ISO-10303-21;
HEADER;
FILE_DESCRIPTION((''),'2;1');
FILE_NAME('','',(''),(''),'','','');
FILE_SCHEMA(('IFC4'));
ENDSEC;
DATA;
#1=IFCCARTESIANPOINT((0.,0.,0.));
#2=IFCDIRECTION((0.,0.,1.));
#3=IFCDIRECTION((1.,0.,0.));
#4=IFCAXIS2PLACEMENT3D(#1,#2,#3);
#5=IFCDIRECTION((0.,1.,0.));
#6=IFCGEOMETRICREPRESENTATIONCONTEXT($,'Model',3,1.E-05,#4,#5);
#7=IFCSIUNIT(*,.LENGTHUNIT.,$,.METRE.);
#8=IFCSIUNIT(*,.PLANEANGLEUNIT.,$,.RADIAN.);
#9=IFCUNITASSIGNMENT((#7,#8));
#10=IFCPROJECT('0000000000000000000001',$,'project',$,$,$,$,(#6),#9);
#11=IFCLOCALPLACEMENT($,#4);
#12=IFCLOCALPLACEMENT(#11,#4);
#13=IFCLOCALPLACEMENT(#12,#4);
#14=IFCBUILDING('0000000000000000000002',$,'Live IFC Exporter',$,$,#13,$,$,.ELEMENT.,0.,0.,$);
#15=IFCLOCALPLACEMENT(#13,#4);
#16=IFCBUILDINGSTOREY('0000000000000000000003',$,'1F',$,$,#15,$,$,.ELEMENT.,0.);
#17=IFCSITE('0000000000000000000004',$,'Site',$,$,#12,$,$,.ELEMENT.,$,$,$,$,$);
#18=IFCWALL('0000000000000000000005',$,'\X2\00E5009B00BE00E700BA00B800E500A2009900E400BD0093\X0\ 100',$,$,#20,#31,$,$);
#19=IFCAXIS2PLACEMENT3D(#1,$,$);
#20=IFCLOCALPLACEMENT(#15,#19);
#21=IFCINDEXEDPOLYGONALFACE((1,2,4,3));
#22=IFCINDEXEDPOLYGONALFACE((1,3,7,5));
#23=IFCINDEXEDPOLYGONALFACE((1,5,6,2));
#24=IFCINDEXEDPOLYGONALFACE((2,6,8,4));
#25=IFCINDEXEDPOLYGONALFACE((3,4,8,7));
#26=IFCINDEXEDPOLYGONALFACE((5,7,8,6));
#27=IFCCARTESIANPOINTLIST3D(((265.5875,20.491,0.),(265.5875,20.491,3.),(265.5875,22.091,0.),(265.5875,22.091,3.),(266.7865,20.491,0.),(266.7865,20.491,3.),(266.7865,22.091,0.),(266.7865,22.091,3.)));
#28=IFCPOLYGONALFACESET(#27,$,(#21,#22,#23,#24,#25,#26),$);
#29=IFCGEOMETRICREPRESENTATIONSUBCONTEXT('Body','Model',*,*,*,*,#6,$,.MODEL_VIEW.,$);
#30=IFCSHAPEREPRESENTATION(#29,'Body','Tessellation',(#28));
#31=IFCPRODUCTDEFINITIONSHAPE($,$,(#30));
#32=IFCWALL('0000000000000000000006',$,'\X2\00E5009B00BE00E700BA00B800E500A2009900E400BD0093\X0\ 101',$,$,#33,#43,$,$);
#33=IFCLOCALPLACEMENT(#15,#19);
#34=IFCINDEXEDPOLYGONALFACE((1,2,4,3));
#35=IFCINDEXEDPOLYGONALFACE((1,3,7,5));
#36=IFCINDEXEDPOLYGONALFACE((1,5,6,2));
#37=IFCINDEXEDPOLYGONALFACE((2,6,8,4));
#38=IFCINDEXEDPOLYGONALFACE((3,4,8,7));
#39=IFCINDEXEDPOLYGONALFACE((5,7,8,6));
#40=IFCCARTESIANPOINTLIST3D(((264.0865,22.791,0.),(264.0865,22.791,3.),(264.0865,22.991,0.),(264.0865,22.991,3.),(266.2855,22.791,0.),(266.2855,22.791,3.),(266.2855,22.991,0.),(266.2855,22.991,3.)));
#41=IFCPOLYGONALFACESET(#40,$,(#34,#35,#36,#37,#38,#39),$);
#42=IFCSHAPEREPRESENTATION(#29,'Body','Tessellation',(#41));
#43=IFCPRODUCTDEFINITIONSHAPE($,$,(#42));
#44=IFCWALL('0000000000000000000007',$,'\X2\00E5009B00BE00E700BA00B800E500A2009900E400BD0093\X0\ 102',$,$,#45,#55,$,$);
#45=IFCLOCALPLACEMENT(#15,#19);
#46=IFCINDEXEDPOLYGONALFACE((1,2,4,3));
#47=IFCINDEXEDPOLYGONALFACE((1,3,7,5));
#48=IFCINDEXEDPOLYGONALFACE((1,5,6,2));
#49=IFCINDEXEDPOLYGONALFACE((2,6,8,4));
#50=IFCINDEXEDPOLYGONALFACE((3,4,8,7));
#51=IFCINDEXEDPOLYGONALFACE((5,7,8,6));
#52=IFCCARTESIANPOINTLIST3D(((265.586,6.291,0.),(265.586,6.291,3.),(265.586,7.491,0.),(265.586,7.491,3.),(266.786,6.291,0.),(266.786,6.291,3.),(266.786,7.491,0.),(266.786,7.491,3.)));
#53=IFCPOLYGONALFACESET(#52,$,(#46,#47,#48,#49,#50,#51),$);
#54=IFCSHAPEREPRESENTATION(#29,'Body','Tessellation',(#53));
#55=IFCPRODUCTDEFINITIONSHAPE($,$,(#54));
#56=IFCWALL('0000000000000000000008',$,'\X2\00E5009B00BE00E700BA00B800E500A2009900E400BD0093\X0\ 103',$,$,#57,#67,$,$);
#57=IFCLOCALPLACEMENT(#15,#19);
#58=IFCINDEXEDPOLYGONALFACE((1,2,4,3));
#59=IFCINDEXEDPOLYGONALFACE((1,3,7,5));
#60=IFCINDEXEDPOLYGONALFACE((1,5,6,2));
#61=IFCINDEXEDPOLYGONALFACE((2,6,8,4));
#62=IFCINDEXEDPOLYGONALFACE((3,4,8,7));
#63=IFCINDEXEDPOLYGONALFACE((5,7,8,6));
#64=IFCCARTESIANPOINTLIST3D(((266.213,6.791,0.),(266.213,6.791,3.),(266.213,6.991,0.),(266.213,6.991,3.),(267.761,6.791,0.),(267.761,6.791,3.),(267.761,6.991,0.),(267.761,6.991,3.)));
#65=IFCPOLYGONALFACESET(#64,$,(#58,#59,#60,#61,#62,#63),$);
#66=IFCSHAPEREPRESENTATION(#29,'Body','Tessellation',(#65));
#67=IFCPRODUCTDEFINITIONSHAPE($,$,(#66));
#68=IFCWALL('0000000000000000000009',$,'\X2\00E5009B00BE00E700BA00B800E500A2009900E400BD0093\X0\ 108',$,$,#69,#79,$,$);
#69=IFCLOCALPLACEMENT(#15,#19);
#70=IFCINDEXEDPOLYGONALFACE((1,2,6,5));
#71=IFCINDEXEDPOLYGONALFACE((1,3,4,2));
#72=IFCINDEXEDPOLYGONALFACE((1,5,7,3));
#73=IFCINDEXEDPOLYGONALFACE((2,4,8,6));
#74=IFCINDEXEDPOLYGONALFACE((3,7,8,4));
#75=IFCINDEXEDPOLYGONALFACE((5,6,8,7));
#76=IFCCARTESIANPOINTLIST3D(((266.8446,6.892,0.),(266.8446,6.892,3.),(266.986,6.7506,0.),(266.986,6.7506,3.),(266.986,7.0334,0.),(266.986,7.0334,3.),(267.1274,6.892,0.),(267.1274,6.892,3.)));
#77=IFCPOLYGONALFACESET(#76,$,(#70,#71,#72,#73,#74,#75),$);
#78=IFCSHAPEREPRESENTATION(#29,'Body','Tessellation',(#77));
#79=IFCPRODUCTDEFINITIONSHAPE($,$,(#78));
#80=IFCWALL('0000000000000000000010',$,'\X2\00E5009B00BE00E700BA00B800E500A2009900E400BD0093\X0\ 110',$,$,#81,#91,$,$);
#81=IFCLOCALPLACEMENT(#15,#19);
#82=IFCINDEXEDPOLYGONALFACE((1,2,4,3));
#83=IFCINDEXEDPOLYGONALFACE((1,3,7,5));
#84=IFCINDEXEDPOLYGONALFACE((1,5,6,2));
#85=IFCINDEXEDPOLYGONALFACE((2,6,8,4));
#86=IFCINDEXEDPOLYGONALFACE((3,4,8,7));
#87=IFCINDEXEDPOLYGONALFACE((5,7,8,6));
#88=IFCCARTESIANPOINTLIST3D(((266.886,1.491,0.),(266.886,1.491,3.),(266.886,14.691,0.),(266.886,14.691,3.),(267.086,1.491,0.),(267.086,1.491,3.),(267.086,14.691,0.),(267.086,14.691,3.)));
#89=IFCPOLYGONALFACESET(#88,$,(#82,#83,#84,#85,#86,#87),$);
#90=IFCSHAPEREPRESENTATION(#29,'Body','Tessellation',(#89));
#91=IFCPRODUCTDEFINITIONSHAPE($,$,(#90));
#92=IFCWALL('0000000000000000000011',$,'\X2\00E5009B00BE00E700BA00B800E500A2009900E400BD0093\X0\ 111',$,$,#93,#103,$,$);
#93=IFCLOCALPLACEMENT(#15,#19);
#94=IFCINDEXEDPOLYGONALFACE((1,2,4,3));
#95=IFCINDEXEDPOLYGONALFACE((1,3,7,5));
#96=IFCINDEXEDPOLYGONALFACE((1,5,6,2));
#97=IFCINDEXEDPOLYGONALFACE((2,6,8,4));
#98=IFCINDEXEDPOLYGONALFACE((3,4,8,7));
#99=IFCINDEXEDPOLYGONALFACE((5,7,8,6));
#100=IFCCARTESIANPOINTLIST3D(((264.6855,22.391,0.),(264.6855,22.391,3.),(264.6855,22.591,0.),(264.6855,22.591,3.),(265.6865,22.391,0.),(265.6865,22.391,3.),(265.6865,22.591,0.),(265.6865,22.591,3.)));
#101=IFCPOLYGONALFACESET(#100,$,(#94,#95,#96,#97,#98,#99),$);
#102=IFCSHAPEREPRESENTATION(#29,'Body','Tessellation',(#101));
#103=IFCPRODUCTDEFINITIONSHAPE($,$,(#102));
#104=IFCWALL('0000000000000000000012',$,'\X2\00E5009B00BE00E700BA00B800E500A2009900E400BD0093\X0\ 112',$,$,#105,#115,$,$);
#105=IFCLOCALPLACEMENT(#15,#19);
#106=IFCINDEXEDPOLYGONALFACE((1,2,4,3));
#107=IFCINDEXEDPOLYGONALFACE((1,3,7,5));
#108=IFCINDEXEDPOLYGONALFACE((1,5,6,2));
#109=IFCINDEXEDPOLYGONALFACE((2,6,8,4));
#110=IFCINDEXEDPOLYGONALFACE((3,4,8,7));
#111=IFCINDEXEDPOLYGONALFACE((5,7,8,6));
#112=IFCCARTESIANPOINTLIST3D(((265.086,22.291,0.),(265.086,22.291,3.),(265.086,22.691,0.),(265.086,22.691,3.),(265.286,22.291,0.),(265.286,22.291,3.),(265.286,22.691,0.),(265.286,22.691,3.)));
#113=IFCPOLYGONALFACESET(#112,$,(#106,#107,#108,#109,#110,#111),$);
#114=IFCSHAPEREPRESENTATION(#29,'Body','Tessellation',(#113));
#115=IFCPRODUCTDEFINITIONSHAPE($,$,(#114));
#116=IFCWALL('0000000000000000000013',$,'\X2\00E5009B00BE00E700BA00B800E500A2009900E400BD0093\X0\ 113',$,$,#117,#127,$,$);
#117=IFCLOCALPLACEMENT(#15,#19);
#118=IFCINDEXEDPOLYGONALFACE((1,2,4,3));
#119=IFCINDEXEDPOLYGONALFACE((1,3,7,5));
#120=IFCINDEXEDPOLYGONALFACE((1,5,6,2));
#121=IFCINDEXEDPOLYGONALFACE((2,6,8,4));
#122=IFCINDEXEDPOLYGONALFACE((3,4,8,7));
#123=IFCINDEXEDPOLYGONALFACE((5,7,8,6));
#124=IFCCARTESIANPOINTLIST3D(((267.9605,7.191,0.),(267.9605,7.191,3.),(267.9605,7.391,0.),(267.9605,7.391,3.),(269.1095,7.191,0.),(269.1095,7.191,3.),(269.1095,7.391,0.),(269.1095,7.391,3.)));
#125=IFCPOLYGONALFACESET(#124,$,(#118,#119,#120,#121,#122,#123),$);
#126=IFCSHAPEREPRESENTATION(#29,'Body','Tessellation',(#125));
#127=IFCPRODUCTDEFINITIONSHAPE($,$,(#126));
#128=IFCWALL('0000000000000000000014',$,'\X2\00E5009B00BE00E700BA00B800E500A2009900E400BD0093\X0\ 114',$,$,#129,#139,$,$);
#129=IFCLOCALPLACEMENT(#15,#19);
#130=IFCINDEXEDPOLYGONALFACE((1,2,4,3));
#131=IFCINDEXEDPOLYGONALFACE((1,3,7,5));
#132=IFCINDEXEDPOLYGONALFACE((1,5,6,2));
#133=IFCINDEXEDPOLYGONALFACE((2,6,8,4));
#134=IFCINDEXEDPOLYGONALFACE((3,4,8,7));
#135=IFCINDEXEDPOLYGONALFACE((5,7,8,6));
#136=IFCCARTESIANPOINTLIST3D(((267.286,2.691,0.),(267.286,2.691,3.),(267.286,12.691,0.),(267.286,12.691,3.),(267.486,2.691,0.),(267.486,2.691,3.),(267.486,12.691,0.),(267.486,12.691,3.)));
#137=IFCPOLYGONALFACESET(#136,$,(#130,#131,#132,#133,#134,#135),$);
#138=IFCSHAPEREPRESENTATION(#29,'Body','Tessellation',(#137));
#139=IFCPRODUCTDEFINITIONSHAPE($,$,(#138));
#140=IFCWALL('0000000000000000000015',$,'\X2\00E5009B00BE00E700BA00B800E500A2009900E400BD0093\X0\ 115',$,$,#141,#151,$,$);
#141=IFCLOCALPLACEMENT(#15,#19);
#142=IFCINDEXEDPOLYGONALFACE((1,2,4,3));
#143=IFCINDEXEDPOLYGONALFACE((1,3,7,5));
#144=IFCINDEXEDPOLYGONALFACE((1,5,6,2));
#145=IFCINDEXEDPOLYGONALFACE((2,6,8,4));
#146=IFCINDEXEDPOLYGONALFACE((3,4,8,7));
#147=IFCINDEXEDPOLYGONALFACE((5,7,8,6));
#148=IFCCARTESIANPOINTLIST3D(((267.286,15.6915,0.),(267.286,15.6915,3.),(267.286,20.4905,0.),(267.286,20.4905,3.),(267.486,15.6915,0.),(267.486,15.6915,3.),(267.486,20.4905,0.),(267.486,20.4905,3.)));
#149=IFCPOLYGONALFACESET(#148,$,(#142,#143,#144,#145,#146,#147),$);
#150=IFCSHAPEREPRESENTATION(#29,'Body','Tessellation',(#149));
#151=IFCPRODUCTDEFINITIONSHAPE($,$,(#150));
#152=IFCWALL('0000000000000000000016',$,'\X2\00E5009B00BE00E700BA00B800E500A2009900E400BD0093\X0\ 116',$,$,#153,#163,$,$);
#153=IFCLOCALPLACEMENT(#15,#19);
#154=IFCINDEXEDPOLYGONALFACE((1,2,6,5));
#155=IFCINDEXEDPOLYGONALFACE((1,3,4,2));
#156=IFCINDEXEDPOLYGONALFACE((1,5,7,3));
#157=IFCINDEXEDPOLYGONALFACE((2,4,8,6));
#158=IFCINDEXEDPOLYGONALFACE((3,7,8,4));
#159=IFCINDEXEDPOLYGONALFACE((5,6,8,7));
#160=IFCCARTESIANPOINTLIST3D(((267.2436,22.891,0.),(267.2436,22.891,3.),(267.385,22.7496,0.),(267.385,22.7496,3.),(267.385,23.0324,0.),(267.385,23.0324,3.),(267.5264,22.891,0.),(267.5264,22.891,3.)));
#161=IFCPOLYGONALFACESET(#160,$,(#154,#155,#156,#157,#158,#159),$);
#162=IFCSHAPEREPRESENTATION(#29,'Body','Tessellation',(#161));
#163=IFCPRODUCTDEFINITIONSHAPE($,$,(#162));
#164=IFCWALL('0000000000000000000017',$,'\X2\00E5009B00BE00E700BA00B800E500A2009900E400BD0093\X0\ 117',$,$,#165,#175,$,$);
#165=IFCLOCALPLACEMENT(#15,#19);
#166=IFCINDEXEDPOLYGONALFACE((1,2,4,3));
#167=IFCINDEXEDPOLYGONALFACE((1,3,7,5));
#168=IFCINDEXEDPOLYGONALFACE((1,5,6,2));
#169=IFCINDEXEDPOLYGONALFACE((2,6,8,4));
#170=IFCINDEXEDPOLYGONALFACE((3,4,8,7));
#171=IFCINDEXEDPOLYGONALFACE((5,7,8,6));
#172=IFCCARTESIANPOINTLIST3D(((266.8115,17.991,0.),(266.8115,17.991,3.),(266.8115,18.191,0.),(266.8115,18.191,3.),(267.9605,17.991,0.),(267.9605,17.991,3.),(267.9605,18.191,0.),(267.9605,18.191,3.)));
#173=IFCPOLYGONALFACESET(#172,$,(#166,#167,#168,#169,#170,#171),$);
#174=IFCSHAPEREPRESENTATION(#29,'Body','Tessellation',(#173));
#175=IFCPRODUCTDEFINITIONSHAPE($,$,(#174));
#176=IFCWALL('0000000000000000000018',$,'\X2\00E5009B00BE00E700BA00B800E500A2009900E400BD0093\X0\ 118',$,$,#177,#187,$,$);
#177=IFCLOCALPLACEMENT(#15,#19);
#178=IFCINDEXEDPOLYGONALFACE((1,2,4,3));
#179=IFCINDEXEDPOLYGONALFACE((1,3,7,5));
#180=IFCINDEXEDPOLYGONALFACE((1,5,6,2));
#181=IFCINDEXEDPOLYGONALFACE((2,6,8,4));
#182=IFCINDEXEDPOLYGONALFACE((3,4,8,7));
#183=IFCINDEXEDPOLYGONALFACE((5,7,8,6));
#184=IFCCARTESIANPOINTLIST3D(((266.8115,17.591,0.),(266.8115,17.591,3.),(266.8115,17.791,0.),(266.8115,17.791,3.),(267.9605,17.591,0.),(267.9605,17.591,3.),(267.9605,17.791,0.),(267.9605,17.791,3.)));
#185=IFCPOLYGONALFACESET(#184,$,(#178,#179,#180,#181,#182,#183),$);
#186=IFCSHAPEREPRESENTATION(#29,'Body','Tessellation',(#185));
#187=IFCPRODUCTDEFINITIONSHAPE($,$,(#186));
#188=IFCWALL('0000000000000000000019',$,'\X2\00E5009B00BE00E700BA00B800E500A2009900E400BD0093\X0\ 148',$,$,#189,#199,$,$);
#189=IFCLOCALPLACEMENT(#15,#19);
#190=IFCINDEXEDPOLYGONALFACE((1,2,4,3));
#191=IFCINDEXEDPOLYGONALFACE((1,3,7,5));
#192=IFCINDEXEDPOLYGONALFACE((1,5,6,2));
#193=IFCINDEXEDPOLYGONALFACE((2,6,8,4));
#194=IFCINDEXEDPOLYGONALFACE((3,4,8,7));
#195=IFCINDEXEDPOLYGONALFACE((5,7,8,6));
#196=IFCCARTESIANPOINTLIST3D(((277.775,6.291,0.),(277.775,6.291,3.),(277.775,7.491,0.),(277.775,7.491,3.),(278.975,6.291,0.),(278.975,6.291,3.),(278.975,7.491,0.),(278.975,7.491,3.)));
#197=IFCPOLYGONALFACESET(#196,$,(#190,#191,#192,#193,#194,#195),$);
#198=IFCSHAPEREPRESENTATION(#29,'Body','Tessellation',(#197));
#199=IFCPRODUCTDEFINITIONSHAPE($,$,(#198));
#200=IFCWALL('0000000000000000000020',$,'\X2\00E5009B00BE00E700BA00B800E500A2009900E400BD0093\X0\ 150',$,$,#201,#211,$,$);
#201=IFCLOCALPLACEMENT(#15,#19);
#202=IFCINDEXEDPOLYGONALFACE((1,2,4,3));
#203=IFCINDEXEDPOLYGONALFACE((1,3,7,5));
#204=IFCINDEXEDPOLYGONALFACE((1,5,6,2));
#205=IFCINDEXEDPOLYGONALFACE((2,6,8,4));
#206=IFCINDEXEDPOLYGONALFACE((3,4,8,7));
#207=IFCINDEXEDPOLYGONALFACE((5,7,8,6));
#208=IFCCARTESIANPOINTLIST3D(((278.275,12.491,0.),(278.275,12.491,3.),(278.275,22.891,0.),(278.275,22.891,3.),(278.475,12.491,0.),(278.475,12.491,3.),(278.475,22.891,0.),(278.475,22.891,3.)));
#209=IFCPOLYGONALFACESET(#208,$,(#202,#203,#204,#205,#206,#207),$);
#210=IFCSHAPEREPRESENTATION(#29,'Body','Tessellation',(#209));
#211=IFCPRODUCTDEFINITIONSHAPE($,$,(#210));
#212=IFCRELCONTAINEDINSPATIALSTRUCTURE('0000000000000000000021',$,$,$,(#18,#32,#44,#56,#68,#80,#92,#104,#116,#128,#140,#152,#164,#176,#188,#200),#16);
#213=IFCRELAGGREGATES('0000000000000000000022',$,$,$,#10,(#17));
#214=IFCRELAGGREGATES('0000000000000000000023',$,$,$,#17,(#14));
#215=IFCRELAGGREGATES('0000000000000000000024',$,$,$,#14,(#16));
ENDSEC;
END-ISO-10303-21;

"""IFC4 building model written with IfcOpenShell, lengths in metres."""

from ifc_helpers import new_model, si_unit, direction, frame, frame_2d, origin_with_axes, place, context, subcontext, project, spatial, rectangle, extrude, element, save


model = new_model("IFC4")

# Units and contexts
model_context = context("Model", 3, precision=1e-05, world=origin_with_axes(), true_north=direction((0.0, 1.0, 0.0)))
body_context = subcontext(model_context, "Body", "Model", "MODEL_VIEW")
ifc_project = project(units=[si_unit("LENGTHUNIT", "METRE"), si_unit("PLANEANGLEUNIT", "RADIAN")], contexts=[model_context])

# Site, building, storey
placement = place(None, origin_with_axes())
site_placement = place(placement, origin_with_axes())
site = spatial("IfcSite", under=ifc_project, at=site_placement, Name="Site", CompositionType="ELEMENT")
building_placement = place(site_placement, origin_with_axes())
building = spatial("IfcBuilding", under=site, at=building_placement, Name="Live IFC Exporter", CompositionType="ELEMENT", ElevationOfRefHeight=0.0, ElevationOfTerrain=0.0)
storey_placement = place(building_placement, origin_with_axes())
storey = spatial("IfcBuildingStorey", under=building, at=storey_placement, Name="1F", CompositionType="ELEMENT", Elevation=0.0)

# Walls
wall_1_placement = place(storey_placement, frame((266.187, 21.291, 0.0), z_axis=(0.0, 0.0, 1.0), x_axis=(1.0, 0.0, 0.0)))
element("IfcWall", 1, at=wall_1_placement, inside=storey, Name="å\u009b¾çº¸å¢\u0099ä½\u0093 100", context=body_context, shape_type="SweptSolid", body=[
    extrude(rectangle(XDim=1.199, YDim=1.6, at=frame_2d((0.0, 0.0), x_axis=(1.0, 0.0, 0.0))), frame((0.0, 0.0, 0.0), z_axis=(0.0, 0.0, 1.0)), (0.0, 0.0, 1.0), 3.0),
])
wall_2_placement = place(storey_placement, frame((265.186, 22.891, 0.0), z_axis=(0.0, 0.0, 1.0), x_axis=(1.0, 0.0, 0.0)))
element("IfcWall", 2, at=wall_2_placement, inside=storey, Name="å\u009b¾çº¸å¢\u0099ä½\u0093 101", context=body_context, shape_type="SweptSolid", body=[
    extrude(rectangle(XDim=2.199, YDim=0.2, at=frame_2d((0.0, 0.0), x_axis=(1.0, 0.0, 0.0))), frame((0.0, 0.0, 0.0), z_axis=(0.0, 0.0, 1.0)), (0.0, 0.0, 1.0), 3.0),
])
wall_3_placement = place(storey_placement, frame((266.186, 6.891, 0.0), z_axis=(0.0, 0.0, 1.0), x_axis=(1.0, 0.0, 0.0)))
element("IfcWall", 3, at=wall_3_placement, inside=storey, Name="å\u009b¾çº¸å¢\u0099ä½\u0093 102", context=body_context, shape_type="SweptSolid", body=[
    extrude(rectangle(XDim=1.2, YDim=1.2, at=frame_2d((0.0, 0.0), x_axis=(1.0, 0.0, 0.0))), frame((0.0, 0.0, 0.0), z_axis=(0.0, 0.0, 1.0)), (0.0, 0.0, 1.0), 3.0),
])
wall_4_placement = place(storey_placement, frame((266.987, 6.891, 0.0), z_axis=(0.0, 0.0, 1.0), x_axis=(1.0, 0.0, 0.0)))
element("IfcWall", 4, at=wall_4_placement, inside=storey, Name="å\u009b¾çº¸å¢\u0099ä½\u0093 103", context=body_context, shape_type="SweptSolid", body=[
    extrude(rectangle(XDim=1.548, YDim=0.2, at=frame_2d((0.0, 0.0), x_axis=(1.0, 0.0, 0.0))), frame((0.0, 0.0, 0.0), z_axis=(0.0, 0.0, 1.0)), (0.0, 0.0, 1.0), 3.0),
])
wall_5_placement = place(storey_placement, frame((266.986, 6.892, 0.0), z_axis=(0.0, 0.0, 1.0), x_axis=(0.707107, -0.707107, 0.0)))
element("IfcWall", 5, at=wall_5_placement, inside=storey, Name="å\u009b¾çº¸å¢\u0099ä½\u0093 108", context=body_context, shape_type="SweptSolid", body=[
    extrude(rectangle(XDim=0.2, YDim=0.2, at=frame_2d((0.0, 0.0), x_axis=(1.0, 0.0, 0.0))), frame((0.0, 0.0, 0.0), z_axis=(0.0, 0.0, 1.0)), (0.0, 0.0, 1.0), 3.0),
])
wall_6_placement = place(storey_placement, frame((266.986, 8.091, 0.0), z_axis=(0.0, 0.0, 1.0), x_axis=(0.0, 1.0, 0.0)))
element("IfcWall", 6, at=wall_6_placement, inside=storey, Name="å\u009b¾çº¸å¢\u0099ä½\u0093 110", context=body_context, shape_type="SweptSolid", body=[
    extrude(rectangle(XDim=13.2, YDim=0.2, at=frame_2d((0.0, 0.0), x_axis=(1.0, 0.0, 0.0))), frame((0.0, 0.0, 0.0), z_axis=(0.0, 0.0, 1.0)), (0.0, 0.0, 1.0), 3.0),
])
wall_7_placement = place(storey_placement, frame((265.186, 22.491, 0.0), z_axis=(0.0, 0.0, 1.0), x_axis=(1.0, 0.0, 0.0)))
element("IfcWall", 7, at=wall_7_placement, inside=storey, Name="å\u009b¾çº¸å¢\u0099ä½\u0093 111", context=body_context, shape_type="SweptSolid", body=[
    extrude(rectangle(XDim=1.001, YDim=0.2, at=frame_2d((0.0, 0.0), x_axis=(1.0, 0.0, 0.0))), frame((0.0, 0.0, 0.0), z_axis=(0.0, 0.0, 1.0)), (0.0, 0.0, 1.0), 3.0),
])
wall_8_placement = place(storey_placement, frame((265.186, 22.491, 0.0), z_axis=(0.0, 0.0, 1.0), x_axis=(0.0, 1.0, 0.0)))
element("IfcWall", 8, at=wall_8_placement, inside=storey, Name="å\u009b¾çº¸å¢\u0099ä½\u0093 112", context=body_context, shape_type="SweptSolid", body=[
    extrude(rectangle(XDim=0.4, YDim=0.2, at=frame_2d((0.0, 0.0), x_axis=(1.0, 0.0, 0.0))), frame((0.0, 0.0, 0.0), z_axis=(0.0, 0.0, 1.0)), (0.0, 0.0, 1.0), 3.0),
])
wall_9_placement = place(storey_placement, frame((268.535, 7.291, 0.0), z_axis=(0.0, 0.0, 1.0), x_axis=(-1.0, 0.0, 0.0)))
element("IfcWall", 9, at=wall_9_placement, inside=storey, Name="å\u009b¾çº¸å¢\u0099ä½\u0093 113", context=body_context, shape_type="SweptSolid", body=[
    extrude(rectangle(XDim=1.149, YDim=0.2, at=frame_2d((0.0, 0.0), x_axis=(1.0, 0.0, 0.0))), frame((0.0, 0.0, 0.0), z_axis=(0.0, 0.0, 1.0)), (0.0, 0.0, 1.0), 3.0),
])
wall_10_placement = place(storey_placement, frame((267.386, 7.691, 0.0), z_axis=(0.0, 0.0, 1.0), x_axis=(0.0, 1.0, 0.0)))
element("IfcWall", 10, at=wall_10_placement, inside=storey, Name="å\u009b¾çº¸å¢\u0099ä½\u0093 114", context=body_context, shape_type="SweptSolid", body=[
    extrude(rectangle(XDim=10.0, YDim=0.2, at=frame_2d((0.0, 0.0), x_axis=(1.0, 0.0, 0.0))), frame((0.0, 0.0, 0.0), z_axis=(0.0, 0.0, 1.0)), (0.0, 0.0, 1.0), 3.0),
])
wall_11_placement = place(storey_placement, frame((267.386, 18.091, 0.0), z_axis=(0.0, 0.0, 1.0), x_axis=(0.0, 1.0, 0.0)))
element("IfcWall", 11, at=wall_11_placement, inside=storey, Name="å\u009b¾çº¸å¢\u0099ä½\u0093 115", context=body_context, shape_type="SweptSolid", body=[
    extrude(rectangle(XDim=4.799, YDim=0.2, at=frame_2d((0.0, 0.0), x_axis=(1.0, 0.0, 0.0))), frame((0.0, 0.0, 0.0), z_axis=(0.0, 0.0, 1.0)), (0.0, 0.0, 1.0), 3.0),
])
wall_12_placement = place(storey_placement, frame((267.385, 22.891, 0.0), z_axis=(0.0, 0.0, 1.0), x_axis=(0.707107, -0.707107, 0.0)))
element("IfcWall", 12, at=wall_12_placement, inside=storey, Name="å\u009b¾çº¸å¢\u0099ä½\u0093 116", context=body_context, shape_type="SweptSolid", body=[
    extrude(rectangle(XDim=0.2, YDim=0.2, at=frame_2d((0.0, 0.0), x_axis=(1.0, 0.0, 0.0))), frame((0.0, 0.0, 0.0), z_axis=(0.0, 0.0, 1.0)), (0.0, 0.0, 1.0), 3.0),
])
for number, where, z_axis, x_axis, name in (
    (13, (267.386, 18.091, 0.0), (0.0, 0.0, 1.0), (1.0, 0.0, 0.0), "å\u009b¾çº¸å¢\u0099ä½\u0093 117"),
    (14, (267.386, 17.691, 0.0), (0.0, 0.0, 1.0), (1.0, 0.0, 0.0), "å\u009b¾çº¸å¢\u0099ä½\u0093 118"),
):
    element("IfcWall", number, at=place(storey_placement, frame(where, z_axis=z_axis, x_axis=x_axis)), inside=storey, Name=name, context=body_context, shape_type="SweptSolid", body=[
        extrude(rectangle(XDim=1.149, YDim=0.2, at=frame_2d((0.0, 0.0), x_axis=(1.0, 0.0, 0.0))), frame((0.0, 0.0, 0.0), z_axis=(0.0, 0.0, 1.0)), (0.0, 0.0, 1.0), 3.0),
    ])
wall_13_placement = place(storey_placement, frame((278.375, 6.891, 0.0), z_axis=(0.0, 0.0, 1.0), x_axis=(1.0, 0.0, 0.0)))
element("IfcWall", 15, at=wall_13_placement, inside=storey, Name="å\u009b¾çº¸å¢\u0099ä½\u0093 148", context=body_context, shape_type="SweptSolid", body=[
    extrude(rectangle(XDim=1.2, YDim=1.2, at=frame_2d((0.0, 0.0), x_axis=(1.0, 0.0, 0.0))), frame((0.0, 0.0, 0.0), z_axis=(0.0, 0.0, 1.0)), (0.0, 0.0, 1.0), 3.0),
])
wall_14_placement = place(storey_placement, frame((278.375, 17.691, 0.0), z_axis=(0.0, 0.0, 1.0), x_axis=(0.0, -1.0, 0.0)))
element("IfcWall", 16, at=wall_14_placement, inside=storey, Name="å\u009b¾çº¸å¢\u0099ä½\u0093 150", context=body_context, shape_type="SweptSolid", body=[
    extrude(rectangle(XDim=10.4, YDim=0.2, at=frame_2d((0.0, 0.0), x_axis=(1.0, 0.0, 0.0))), frame((0.0, 0.0, 0.0), z_axis=(0.0, 0.0, 1.0)), (0.0, 0.0, 1.0), 3.0),
])

save(model, "model.ifc")
